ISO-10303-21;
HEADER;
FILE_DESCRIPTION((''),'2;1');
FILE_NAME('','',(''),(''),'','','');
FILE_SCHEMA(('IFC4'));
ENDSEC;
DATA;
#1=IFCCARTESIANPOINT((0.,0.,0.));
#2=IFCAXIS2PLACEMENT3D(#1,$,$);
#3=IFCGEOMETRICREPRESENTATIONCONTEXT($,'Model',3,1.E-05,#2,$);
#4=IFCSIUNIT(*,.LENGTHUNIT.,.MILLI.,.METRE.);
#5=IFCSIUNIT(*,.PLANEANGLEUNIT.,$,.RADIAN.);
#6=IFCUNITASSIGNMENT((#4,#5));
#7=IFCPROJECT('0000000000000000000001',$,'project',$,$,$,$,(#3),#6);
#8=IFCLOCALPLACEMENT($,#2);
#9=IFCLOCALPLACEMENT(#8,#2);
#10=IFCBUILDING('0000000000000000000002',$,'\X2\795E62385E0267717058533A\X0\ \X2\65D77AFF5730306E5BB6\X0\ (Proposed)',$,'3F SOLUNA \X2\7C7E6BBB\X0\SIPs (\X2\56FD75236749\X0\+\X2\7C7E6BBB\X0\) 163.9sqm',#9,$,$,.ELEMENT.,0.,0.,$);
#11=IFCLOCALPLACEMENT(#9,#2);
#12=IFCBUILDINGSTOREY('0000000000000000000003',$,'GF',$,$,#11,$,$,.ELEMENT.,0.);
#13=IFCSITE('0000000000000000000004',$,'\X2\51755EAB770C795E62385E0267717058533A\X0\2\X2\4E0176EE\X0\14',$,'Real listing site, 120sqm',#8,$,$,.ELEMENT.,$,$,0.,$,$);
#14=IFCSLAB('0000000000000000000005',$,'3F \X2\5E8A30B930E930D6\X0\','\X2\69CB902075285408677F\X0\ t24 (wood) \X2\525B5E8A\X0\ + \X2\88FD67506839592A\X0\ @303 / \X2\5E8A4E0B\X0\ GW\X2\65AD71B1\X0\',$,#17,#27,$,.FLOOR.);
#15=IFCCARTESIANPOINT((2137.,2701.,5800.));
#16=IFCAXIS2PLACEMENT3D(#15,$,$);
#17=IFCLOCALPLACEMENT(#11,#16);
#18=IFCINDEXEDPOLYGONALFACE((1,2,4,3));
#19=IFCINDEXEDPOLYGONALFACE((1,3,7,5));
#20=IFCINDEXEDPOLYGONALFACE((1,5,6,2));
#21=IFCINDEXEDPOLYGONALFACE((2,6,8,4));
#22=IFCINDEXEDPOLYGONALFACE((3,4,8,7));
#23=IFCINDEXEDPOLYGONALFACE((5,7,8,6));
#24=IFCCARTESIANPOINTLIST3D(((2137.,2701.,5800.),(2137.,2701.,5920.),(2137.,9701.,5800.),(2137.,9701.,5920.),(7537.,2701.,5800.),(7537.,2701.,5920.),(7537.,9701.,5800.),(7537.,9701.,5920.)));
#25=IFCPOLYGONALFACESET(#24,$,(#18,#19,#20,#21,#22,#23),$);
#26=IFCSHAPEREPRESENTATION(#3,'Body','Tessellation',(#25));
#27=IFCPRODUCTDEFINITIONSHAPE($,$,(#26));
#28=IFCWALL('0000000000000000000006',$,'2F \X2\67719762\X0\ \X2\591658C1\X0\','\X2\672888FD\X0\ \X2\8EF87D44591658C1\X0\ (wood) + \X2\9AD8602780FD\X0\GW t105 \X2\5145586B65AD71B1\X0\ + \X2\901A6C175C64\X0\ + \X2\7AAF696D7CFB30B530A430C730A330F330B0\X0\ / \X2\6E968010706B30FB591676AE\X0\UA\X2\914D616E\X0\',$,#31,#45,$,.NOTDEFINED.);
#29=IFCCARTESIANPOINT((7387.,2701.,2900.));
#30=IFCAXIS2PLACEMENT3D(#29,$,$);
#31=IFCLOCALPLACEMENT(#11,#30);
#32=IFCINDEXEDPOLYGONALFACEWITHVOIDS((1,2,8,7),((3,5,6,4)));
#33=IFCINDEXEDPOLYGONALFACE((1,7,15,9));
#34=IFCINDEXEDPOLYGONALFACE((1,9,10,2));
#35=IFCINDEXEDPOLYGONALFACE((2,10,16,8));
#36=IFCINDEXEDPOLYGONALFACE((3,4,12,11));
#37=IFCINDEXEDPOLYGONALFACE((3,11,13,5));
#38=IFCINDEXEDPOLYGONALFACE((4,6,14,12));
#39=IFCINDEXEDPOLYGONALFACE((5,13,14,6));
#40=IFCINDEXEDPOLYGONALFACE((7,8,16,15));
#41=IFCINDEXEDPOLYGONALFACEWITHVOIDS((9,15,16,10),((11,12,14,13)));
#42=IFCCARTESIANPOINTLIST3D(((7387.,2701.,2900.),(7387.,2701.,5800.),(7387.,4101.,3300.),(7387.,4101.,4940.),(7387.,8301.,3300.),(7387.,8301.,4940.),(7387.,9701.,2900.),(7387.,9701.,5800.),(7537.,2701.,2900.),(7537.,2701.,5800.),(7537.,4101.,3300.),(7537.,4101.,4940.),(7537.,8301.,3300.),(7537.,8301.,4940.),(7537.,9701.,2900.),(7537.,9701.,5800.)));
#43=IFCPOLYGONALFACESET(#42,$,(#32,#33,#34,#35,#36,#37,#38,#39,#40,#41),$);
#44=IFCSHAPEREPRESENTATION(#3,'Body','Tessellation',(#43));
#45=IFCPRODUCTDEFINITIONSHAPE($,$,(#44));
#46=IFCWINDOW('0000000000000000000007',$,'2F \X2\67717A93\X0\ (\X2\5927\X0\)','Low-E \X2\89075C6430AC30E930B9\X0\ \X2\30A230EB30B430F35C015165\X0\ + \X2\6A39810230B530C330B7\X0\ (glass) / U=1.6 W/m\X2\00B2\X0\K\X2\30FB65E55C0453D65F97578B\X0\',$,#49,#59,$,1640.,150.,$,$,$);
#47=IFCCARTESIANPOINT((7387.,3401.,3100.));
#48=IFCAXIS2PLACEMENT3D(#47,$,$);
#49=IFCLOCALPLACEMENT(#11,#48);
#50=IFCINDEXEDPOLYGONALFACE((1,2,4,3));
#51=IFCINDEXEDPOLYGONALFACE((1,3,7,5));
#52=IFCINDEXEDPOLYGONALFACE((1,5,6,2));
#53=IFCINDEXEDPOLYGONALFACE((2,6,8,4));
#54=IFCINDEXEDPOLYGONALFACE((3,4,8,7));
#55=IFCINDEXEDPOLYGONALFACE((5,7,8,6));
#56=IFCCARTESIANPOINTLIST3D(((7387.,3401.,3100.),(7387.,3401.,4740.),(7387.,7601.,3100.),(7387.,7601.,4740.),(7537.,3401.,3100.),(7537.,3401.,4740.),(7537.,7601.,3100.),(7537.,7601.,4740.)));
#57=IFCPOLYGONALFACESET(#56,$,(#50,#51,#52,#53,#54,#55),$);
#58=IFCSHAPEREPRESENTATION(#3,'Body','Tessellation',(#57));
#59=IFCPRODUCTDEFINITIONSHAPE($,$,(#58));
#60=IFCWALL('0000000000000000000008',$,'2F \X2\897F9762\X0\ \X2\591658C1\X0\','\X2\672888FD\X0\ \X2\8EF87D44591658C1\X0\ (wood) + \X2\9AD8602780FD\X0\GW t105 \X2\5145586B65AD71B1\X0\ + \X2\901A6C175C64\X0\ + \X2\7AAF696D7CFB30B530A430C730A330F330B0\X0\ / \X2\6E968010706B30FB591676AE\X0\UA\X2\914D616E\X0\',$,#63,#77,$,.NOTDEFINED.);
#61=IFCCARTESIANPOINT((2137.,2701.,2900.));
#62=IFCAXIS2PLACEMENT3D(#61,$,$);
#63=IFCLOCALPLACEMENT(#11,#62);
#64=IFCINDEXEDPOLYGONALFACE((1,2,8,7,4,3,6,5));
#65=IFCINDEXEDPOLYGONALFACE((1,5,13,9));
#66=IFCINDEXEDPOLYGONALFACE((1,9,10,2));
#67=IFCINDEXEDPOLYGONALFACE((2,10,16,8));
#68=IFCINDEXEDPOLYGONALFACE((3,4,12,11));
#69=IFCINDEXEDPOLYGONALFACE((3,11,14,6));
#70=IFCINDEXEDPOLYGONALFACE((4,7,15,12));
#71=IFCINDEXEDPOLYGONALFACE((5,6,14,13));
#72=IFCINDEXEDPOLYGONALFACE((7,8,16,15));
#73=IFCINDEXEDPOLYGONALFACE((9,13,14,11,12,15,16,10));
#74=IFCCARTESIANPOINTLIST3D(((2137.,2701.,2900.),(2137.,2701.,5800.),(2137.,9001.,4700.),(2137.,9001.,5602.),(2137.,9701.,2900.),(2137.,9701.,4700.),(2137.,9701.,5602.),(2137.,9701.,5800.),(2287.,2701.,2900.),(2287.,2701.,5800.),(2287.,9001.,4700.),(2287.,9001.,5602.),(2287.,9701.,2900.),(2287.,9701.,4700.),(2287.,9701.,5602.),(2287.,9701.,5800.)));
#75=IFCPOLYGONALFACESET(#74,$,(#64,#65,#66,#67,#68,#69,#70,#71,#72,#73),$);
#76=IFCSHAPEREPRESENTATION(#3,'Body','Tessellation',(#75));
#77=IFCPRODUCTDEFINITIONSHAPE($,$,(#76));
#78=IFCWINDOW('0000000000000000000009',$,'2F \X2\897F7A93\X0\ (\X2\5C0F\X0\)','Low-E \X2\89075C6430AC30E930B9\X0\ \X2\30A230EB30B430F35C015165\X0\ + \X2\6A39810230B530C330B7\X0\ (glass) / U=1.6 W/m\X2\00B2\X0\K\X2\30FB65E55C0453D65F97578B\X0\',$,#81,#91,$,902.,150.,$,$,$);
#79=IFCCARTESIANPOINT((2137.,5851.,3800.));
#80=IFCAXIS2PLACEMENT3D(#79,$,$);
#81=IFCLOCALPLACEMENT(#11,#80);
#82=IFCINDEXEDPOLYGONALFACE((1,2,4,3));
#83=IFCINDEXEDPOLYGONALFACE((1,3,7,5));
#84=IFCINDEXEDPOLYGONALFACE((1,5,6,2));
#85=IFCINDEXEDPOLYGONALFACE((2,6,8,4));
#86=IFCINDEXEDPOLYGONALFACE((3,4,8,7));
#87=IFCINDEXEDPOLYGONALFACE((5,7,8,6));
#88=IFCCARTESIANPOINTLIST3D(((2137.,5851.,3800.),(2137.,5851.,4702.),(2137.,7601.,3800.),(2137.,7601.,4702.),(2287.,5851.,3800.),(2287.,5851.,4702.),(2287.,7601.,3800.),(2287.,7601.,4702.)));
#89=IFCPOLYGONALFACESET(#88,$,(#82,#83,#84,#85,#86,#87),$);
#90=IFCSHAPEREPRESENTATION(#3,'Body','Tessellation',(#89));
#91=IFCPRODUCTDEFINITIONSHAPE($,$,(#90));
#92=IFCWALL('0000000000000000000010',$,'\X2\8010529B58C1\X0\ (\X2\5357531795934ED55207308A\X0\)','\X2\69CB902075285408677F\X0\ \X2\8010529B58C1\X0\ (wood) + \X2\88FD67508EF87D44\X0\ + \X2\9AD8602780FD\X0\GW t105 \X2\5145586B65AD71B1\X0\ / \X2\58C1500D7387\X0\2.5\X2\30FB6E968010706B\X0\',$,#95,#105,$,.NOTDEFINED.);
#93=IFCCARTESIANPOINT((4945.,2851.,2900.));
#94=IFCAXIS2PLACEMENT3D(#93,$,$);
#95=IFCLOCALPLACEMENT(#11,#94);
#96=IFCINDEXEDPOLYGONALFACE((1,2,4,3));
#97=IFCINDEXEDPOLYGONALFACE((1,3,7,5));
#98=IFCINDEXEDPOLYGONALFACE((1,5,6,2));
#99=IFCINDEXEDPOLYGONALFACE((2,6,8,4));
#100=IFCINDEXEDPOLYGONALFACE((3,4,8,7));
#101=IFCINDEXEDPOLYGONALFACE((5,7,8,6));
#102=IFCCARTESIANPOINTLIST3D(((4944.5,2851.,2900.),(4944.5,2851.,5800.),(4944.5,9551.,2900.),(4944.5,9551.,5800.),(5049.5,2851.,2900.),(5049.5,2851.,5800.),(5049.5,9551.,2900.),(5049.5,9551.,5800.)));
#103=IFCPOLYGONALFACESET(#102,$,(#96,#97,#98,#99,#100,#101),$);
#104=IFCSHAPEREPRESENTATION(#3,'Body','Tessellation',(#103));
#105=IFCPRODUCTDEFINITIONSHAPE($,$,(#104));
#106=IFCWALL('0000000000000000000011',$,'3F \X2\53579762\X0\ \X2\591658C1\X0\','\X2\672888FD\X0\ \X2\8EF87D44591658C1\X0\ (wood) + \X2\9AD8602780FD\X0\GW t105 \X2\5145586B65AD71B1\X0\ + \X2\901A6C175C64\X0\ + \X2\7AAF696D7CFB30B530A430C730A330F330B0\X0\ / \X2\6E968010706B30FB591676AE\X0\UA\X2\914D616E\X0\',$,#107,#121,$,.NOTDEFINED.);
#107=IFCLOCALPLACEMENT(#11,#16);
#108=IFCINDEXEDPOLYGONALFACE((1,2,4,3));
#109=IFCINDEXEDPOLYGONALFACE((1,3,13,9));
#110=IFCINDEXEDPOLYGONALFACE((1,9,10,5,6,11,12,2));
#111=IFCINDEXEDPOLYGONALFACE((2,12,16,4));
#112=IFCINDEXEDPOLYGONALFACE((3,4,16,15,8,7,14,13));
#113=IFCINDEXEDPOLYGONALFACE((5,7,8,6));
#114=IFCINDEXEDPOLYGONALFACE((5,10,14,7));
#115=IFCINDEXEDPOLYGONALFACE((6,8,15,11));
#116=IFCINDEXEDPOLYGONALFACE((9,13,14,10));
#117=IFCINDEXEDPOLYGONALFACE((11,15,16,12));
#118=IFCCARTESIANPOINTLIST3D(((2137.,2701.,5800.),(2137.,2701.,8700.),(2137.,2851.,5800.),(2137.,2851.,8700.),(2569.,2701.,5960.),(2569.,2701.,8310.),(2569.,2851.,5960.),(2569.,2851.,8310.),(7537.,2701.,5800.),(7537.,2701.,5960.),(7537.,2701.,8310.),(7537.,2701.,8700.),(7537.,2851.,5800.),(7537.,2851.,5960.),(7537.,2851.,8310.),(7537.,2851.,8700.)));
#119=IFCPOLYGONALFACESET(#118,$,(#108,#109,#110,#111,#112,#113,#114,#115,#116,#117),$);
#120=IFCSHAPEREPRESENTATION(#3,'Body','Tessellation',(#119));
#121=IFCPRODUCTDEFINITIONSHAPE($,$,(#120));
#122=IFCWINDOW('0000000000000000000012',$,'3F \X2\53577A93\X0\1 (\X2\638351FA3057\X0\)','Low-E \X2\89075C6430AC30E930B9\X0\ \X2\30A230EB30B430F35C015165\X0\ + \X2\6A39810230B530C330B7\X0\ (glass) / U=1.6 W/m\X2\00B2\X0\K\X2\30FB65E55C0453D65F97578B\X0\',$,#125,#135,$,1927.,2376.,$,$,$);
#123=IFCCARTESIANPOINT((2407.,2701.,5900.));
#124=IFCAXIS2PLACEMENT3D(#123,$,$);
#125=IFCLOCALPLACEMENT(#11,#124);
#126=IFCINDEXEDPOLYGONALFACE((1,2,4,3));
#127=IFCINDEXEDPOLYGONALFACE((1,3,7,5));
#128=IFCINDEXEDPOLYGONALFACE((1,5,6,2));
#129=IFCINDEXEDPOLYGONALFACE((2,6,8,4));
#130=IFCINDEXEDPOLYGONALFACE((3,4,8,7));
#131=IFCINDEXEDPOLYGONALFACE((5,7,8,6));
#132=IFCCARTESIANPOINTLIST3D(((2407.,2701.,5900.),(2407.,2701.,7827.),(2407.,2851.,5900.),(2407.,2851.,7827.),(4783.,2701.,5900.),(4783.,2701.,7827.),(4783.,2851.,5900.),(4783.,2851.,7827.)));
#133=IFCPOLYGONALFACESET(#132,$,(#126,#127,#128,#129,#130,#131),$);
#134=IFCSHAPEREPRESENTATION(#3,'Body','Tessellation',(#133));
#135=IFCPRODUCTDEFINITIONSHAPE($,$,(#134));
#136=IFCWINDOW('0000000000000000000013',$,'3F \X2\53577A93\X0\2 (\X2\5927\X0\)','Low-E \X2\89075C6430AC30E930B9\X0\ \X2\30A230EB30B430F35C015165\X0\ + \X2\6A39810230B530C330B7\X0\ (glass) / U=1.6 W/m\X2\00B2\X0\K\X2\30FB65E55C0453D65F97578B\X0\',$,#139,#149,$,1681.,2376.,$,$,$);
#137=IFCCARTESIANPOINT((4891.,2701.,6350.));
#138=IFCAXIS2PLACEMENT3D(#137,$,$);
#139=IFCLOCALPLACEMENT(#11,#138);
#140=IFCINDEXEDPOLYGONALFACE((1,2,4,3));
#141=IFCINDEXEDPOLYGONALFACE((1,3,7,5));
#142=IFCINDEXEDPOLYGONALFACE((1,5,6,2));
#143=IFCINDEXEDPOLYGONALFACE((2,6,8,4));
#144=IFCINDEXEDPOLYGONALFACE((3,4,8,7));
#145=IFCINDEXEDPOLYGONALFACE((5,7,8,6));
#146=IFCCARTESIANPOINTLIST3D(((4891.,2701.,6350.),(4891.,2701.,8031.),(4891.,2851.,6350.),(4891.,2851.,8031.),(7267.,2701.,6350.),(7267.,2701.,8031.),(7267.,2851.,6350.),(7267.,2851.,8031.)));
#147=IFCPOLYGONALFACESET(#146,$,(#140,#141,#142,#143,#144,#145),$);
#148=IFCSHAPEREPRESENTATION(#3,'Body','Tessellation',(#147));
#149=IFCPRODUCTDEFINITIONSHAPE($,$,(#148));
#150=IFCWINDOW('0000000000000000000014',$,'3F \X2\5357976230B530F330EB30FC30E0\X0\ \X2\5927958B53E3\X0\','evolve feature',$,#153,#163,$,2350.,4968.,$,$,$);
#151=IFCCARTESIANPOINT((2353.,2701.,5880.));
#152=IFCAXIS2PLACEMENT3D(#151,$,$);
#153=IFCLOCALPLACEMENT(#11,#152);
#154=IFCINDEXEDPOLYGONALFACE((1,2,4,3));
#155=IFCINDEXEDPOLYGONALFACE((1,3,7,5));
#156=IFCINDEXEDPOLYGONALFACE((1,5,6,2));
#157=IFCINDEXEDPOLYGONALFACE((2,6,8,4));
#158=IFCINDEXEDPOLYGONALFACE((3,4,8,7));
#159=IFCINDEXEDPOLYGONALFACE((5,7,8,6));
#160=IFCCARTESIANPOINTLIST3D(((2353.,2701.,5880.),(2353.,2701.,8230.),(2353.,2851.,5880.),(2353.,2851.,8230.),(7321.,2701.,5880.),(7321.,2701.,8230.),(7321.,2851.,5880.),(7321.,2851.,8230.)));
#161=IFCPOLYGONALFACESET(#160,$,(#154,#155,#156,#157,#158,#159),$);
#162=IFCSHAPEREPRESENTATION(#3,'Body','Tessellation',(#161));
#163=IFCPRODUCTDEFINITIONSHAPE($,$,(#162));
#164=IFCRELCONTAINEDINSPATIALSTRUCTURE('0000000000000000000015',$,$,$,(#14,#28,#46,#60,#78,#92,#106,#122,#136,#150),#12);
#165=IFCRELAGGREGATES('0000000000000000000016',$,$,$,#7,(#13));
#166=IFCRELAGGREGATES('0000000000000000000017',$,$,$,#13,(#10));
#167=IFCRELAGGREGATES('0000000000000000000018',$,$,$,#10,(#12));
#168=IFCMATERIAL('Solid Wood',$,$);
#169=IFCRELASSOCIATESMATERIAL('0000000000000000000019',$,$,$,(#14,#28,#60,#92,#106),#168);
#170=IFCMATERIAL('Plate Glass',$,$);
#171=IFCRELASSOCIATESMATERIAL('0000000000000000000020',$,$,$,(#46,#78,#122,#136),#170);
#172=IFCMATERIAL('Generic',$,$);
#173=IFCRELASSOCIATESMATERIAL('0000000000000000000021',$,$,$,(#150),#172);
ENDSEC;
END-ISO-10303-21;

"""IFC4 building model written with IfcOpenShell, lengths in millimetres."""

from ifc_helpers import new_model, si_unit, frame, frame_2d, origin, place, context, project, spatial, rectangle, extrude, material, element, fill, save


model = new_model("IFC4")

# Units and contexts
model_context = context("Model", 3, precision=1e-05, world=origin())
ifc_project = project(units=[si_unit("LENGTHUNIT", "METRE", prefix="MILLI"), si_unit("PLANEANGLEUNIT", "RADIAN")], contexts=[model_context])

# Site, building, storey
site_placement = place(None, origin())
site = spatial("IfcSite", under=ifc_project, at=site_placement, Name="兵庫県神戸市東灘区2丁目14", ObjectType="Real listing site, 120sqm", CompositionType="ELEMENT", RefElevation=0.0)
building_placement = place(site_placement, origin())
building = spatial("IfcBuilding", under=site, at=building_placement, Name="神戸市東灘区 旗竿地の家 (Proposed)", ObjectType="3F SOLUNA 籾殻SIPs (国産杉+籾殻) 163.9sqm", CompositionType="ELEMENT", ElevationOfRefHeight=0.0, ElevationOfTerrain=0.0)
storey_placement = place(building_placement, origin())
storey = spatial("IfcBuildingStorey", under=building, at=storey_placement, Name="GF", CompositionType="ELEMENT", Elevation=0.0)

# Slab
ifc_material_1 = material(Name="Solid Wood")
slab_placement = place(storey_placement, frame((2137.0, 2701.0, 5800.0)))
element("IfcSlab", 1, at=slab_placement, inside=storey, material=ifc_material_1, Name="3F 床スラブ", Description="構造用合板 t24 (wood) 剛床 + 製材根太 @303 / 床下 GW断熱", PredefinedType="FLOOR", context=model_context, shape_type="SweptSolid", body=[
    extrude(rectangle(XDim=5400.0, YDim=7000.0, at=frame_2d((2700.0, 3500.0))), frame((2137.0, 2701.0, 5800.0)), (0.0, 0.0, 1.0), 120.0),
])

# Walls, openings, windows
wall_1_placement = place(storey_placement, frame((7387.0, 2701.0, 2900.0)))
wall_1 = element("IfcWall", 2, at=wall_1_placement, inside=storey, material=ifc_material_1, Name="2F 東面 外壁", Description="木製 軸組外壁 (wood) + 高性能GW t105 充填断熱 + 通気層 + 窯業系サイディング / 準耐火・外皮UA配慮", PredefinedType="NOTDEFINED", context=model_context, shape_type="SweptSolid", body=[
    extrude(rectangle(XDim=150.0, YDim=7000.0, at=frame_2d((75.0, 3500.0))), frame((7387.0, 2701.0, 2900.0)), (0.0, 0.0, 1.0), 2900.0),
])
opening_1_placement = place(storey_placement, frame((7387.0, 3401.0, 3100.0)))
opening_1 = element("IfcOpeningElement", 3, at=opening_1_placement, cuts=wall_1, PredefinedType="NOTDEFINED", context=model_context, shape_type="SweptSolid", body=[
    extrude(rectangle(XDim=150.0, YDim=4200.0, at=frame_2d((75.0, 2100.0))), frame((7387.0, 3401.0, 3100.0)), (0.0, 0.0, 1.0), 1640.0),
])
ifc_material_2 = material(Name="Plate Glass")
window_1_placement = place(storey_placement, frame((7387.0, 3401.0, 3100.0)))
window_1 = element("IfcWindow", 4, at=window_1_placement, inside=storey, material=ifc_material_2, Name="2F 東窓 (大)", Description="Low-E 複層ガラス アルゴン封入 + 樹脂サッシ (glass) / U=1.6 W/m²K・日射取得型", OverallHeight=1640.0, OverallWidth=150.0, context=model_context, shape_type="SweptSolid", body=[
    extrude(rectangle(XDim=150.0, YDim=4200.0, at=frame_2d((75.0, 2100.0))), frame((7387.0, 3401.0, 3100.0)), (0.0, 0.0, 1.0), 1640.0),
])
fill(opening_1, window_1)
wall_2_placement = place(storey_placement, frame((2137.0, 2701.0, 2900.0)))
wall_2 = element("IfcWall", 5, at=wall_2_placement, inside=storey, material=ifc_material_1, Name="2F 西面 外壁", Description="木製 軸組外壁 (wood) + 高性能GW t105 充填断熱 + 通気層 + 窯業系サイディング / 準耐火・外皮UA配慮", PredefinedType="NOTDEFINED", context=model_context, shape_type="SweptSolid", body=[
    extrude(rectangle(XDim=150.0, YDim=7000.0, at=frame_2d((75.0, 3500.0))), frame((2137.0, 2701.0, 2900.0)), (0.0, 0.0, 1.0), 2900.0),
])
opening_2_placement = place(storey_placement, frame((2137.0, 5851.0, 3800.0)))
opening_2 = element("IfcOpeningElement", 6, at=opening_2_placement, cuts=wall_2, PredefinedType="NOTDEFINED", context=model_context, shape_type="SweptSolid", body=[
    extrude(rectangle(XDim=150.0, YDim=1750.0, at=frame_2d((75.0, 875.0))), frame((2137.0, 5851.0, 3800.0)), (0.0, 0.0, 1.0), 902.0),
])
window_2_placement = place(storey_placement, frame((2137.0, 5851.0, 3800.0)))
window_2 = element("IfcWindow", 7, at=window_2_placement, inside=storey, material=ifc_material_2, Name="2F 西窓 (小)", Description="Low-E 複層ガラス アルゴン封入 + 樹脂サッシ (glass) / U=1.6 W/m²K・日射取得型", OverallHeight=902.0, OverallWidth=150.0, context=model_context, shape_type="SweptSolid", body=[
    extrude(rectangle(XDim=150.0, YDim=1750.0, at=frame_2d((75.0, 875.0))), frame((2137.0, 5851.0, 3800.0)), (0.0, 0.0, 1.0), 902.0),
])
fill(opening_2, window_2)

# Wall
wall_3_placement = place(storey_placement, frame((4945.0, 2851.0, 2900.0)))
element("IfcWall", 8, at=wall_3_placement, inside=storey, material=ifc_material_1, Name="耐力壁 (南北間仕切り)", Description="構造用合板 耐力壁 (wood) + 製材軸組 + 高性能GW t105 充填断熱 / 壁倍率2.5・準耐火", PredefinedType="NOTDEFINED", context=model_context, shape_type="SweptSolid", body=[
    extrude(rectangle(XDim=105.0, YDim=6700.0, at=frame_2d((52.0, 3350.0))), frame((4945.0, 2851.0, 2900.0)), (0.0, 0.0, 1.0), 2900.0),
])

# Wall, openings, windows
wall_4_placement = place(storey_placement, frame((2137.0, 2701.0, 5800.0)))
wall_4 = element("IfcWall", 9, at=wall_4_placement, inside=storey, material=ifc_material_1, Name="3F 南面 外壁", Description="木製 軸組外壁 (wood) + 高性能GW t105 充填断熱 + 通気層 + 窯業系サイディング / 準耐火・外皮UA配慮", PredefinedType="NOTDEFINED", context=model_context, shape_type="SweptSolid", body=[
    extrude(rectangle(XDim=5400.0, YDim=150.0, at=frame_2d((2700.0, 75.0))), frame((2137.0, 2701.0, 5800.0)), (0.0, 0.0, 1.0), 2900.0),
])
opening_3_placement = place(storey_placement, frame((2407.0, 2701.0, 5900.0)))
opening_3 = element("IfcOpeningElement", 10, at=opening_3_placement, cuts=wall_4, PredefinedType="NOTDEFINED", context=model_context, shape_type="SweptSolid", body=[
    extrude(rectangle(XDim=2376.0, YDim=150.0, at=frame_2d((1188.0, 75.0))), frame((2407.0, 2701.0, 5900.0)), (0.0, 0.0, 1.0), 1927.0),
])
opening_4_placement = place(storey_placement, frame((4891.0, 2701.0, 6350.0)))
opening_4 = element("IfcOpeningElement", 11, at=opening_4_placement, cuts=wall_4, PredefinedType="NOTDEFINED", context=model_context, shape_type="SweptSolid", body=[
    extrude(rectangle(XDim=2376.0, YDim=150.0, at=frame_2d((1188.0, 75.0))), frame((4891.0, 2701.0, 6350.0)), (0.0, 0.0, 1.0), 1681.0),
])
opening_5_placement = place(storey_placement, frame((2353.0, 2701.0, 5880.0)))
opening_5 = element("IfcOpeningElement", 12, at=opening_5_placement, cuts=wall_4, PredefinedType="NOTDEFINED", context=model_context, shape_type="SweptSolid", body=[
    extrude(rectangle(XDim=4968.0, YDim=150.0, at=frame_2d((2484.0, 75.0))), frame((2353.0, 2701.0, 5880.0)), (0.0, 0.0, 1.0), 2350.0),
])
window_3_placement = place(storey_placement, frame((2407.0, 2701.0, 5900.0)))
window_3 = element("IfcWindow", 13, at=window_3_placement, inside=storey, material=ifc_material_2, Name="3F 南窓1 (掃出し)", Description="Low-E 複層ガラス アルゴン封入 + 樹脂サッシ (glass) / U=1.6 W/m²K・日射取得型", OverallHeight=1927.0, OverallWidth=2376.0, context=model_context, shape_type="SweptSolid", body=[
    extrude(rectangle(XDim=2376.0, YDim=150.0, at=frame_2d((1188.0, 75.0))), frame((2407.0, 2701.0, 5900.0)), (0.0, 0.0, 1.0), 1927.0),
])
fill(opening_3, window_3)
window_4_placement = place(storey_placement, frame((4891.0, 2701.0, 6350.0)))
window_4 = element("IfcWindow", 14, at=window_4_placement, inside=storey, material=ifc_material_2, Name="3F 南窓2 (大)", Description="Low-E 複層ガラス アルゴン封入 + 樹脂サッシ (glass) / U=1.6 W/m²K・日射取得型", OverallHeight=1681.0, OverallWidth=2376.0, context=model_context, shape_type="SweptSolid", body=[
    extrude(rectangle(XDim=2376.0, YDim=150.0, at=frame_2d((1188.0, 75.0))), frame((4891.0, 2701.0, 6350.0)), (0.0, 0.0, 1.0), 1681.0),
])
fill(opening_4, window_4)
ifc_material_3 = material(Name="Generic")
window_5_placement = place(storey_placement, frame((2353.0, 2701.0, 5880.0)))
window_5 = element("IfcWindow", 15, at=window_5_placement, inside=storey, material=ifc_material_3, Name="3F 南面サンルーム 大開口", Description="evolve feature", OverallHeight=2350.0, OverallWidth=4968.0, context=model_context, shape_type="SweptSolid", body=[
    extrude(rectangle(XDim=4968.0, YDim=150.0, at=frame_2d((2484.0, 75.0))), frame((2353.0, 2701.0, 5880.0)), (0.0, 0.0, 1.0), 2350.0),
])
fill(opening_5, window_5)

save(model, "model.ifc")
